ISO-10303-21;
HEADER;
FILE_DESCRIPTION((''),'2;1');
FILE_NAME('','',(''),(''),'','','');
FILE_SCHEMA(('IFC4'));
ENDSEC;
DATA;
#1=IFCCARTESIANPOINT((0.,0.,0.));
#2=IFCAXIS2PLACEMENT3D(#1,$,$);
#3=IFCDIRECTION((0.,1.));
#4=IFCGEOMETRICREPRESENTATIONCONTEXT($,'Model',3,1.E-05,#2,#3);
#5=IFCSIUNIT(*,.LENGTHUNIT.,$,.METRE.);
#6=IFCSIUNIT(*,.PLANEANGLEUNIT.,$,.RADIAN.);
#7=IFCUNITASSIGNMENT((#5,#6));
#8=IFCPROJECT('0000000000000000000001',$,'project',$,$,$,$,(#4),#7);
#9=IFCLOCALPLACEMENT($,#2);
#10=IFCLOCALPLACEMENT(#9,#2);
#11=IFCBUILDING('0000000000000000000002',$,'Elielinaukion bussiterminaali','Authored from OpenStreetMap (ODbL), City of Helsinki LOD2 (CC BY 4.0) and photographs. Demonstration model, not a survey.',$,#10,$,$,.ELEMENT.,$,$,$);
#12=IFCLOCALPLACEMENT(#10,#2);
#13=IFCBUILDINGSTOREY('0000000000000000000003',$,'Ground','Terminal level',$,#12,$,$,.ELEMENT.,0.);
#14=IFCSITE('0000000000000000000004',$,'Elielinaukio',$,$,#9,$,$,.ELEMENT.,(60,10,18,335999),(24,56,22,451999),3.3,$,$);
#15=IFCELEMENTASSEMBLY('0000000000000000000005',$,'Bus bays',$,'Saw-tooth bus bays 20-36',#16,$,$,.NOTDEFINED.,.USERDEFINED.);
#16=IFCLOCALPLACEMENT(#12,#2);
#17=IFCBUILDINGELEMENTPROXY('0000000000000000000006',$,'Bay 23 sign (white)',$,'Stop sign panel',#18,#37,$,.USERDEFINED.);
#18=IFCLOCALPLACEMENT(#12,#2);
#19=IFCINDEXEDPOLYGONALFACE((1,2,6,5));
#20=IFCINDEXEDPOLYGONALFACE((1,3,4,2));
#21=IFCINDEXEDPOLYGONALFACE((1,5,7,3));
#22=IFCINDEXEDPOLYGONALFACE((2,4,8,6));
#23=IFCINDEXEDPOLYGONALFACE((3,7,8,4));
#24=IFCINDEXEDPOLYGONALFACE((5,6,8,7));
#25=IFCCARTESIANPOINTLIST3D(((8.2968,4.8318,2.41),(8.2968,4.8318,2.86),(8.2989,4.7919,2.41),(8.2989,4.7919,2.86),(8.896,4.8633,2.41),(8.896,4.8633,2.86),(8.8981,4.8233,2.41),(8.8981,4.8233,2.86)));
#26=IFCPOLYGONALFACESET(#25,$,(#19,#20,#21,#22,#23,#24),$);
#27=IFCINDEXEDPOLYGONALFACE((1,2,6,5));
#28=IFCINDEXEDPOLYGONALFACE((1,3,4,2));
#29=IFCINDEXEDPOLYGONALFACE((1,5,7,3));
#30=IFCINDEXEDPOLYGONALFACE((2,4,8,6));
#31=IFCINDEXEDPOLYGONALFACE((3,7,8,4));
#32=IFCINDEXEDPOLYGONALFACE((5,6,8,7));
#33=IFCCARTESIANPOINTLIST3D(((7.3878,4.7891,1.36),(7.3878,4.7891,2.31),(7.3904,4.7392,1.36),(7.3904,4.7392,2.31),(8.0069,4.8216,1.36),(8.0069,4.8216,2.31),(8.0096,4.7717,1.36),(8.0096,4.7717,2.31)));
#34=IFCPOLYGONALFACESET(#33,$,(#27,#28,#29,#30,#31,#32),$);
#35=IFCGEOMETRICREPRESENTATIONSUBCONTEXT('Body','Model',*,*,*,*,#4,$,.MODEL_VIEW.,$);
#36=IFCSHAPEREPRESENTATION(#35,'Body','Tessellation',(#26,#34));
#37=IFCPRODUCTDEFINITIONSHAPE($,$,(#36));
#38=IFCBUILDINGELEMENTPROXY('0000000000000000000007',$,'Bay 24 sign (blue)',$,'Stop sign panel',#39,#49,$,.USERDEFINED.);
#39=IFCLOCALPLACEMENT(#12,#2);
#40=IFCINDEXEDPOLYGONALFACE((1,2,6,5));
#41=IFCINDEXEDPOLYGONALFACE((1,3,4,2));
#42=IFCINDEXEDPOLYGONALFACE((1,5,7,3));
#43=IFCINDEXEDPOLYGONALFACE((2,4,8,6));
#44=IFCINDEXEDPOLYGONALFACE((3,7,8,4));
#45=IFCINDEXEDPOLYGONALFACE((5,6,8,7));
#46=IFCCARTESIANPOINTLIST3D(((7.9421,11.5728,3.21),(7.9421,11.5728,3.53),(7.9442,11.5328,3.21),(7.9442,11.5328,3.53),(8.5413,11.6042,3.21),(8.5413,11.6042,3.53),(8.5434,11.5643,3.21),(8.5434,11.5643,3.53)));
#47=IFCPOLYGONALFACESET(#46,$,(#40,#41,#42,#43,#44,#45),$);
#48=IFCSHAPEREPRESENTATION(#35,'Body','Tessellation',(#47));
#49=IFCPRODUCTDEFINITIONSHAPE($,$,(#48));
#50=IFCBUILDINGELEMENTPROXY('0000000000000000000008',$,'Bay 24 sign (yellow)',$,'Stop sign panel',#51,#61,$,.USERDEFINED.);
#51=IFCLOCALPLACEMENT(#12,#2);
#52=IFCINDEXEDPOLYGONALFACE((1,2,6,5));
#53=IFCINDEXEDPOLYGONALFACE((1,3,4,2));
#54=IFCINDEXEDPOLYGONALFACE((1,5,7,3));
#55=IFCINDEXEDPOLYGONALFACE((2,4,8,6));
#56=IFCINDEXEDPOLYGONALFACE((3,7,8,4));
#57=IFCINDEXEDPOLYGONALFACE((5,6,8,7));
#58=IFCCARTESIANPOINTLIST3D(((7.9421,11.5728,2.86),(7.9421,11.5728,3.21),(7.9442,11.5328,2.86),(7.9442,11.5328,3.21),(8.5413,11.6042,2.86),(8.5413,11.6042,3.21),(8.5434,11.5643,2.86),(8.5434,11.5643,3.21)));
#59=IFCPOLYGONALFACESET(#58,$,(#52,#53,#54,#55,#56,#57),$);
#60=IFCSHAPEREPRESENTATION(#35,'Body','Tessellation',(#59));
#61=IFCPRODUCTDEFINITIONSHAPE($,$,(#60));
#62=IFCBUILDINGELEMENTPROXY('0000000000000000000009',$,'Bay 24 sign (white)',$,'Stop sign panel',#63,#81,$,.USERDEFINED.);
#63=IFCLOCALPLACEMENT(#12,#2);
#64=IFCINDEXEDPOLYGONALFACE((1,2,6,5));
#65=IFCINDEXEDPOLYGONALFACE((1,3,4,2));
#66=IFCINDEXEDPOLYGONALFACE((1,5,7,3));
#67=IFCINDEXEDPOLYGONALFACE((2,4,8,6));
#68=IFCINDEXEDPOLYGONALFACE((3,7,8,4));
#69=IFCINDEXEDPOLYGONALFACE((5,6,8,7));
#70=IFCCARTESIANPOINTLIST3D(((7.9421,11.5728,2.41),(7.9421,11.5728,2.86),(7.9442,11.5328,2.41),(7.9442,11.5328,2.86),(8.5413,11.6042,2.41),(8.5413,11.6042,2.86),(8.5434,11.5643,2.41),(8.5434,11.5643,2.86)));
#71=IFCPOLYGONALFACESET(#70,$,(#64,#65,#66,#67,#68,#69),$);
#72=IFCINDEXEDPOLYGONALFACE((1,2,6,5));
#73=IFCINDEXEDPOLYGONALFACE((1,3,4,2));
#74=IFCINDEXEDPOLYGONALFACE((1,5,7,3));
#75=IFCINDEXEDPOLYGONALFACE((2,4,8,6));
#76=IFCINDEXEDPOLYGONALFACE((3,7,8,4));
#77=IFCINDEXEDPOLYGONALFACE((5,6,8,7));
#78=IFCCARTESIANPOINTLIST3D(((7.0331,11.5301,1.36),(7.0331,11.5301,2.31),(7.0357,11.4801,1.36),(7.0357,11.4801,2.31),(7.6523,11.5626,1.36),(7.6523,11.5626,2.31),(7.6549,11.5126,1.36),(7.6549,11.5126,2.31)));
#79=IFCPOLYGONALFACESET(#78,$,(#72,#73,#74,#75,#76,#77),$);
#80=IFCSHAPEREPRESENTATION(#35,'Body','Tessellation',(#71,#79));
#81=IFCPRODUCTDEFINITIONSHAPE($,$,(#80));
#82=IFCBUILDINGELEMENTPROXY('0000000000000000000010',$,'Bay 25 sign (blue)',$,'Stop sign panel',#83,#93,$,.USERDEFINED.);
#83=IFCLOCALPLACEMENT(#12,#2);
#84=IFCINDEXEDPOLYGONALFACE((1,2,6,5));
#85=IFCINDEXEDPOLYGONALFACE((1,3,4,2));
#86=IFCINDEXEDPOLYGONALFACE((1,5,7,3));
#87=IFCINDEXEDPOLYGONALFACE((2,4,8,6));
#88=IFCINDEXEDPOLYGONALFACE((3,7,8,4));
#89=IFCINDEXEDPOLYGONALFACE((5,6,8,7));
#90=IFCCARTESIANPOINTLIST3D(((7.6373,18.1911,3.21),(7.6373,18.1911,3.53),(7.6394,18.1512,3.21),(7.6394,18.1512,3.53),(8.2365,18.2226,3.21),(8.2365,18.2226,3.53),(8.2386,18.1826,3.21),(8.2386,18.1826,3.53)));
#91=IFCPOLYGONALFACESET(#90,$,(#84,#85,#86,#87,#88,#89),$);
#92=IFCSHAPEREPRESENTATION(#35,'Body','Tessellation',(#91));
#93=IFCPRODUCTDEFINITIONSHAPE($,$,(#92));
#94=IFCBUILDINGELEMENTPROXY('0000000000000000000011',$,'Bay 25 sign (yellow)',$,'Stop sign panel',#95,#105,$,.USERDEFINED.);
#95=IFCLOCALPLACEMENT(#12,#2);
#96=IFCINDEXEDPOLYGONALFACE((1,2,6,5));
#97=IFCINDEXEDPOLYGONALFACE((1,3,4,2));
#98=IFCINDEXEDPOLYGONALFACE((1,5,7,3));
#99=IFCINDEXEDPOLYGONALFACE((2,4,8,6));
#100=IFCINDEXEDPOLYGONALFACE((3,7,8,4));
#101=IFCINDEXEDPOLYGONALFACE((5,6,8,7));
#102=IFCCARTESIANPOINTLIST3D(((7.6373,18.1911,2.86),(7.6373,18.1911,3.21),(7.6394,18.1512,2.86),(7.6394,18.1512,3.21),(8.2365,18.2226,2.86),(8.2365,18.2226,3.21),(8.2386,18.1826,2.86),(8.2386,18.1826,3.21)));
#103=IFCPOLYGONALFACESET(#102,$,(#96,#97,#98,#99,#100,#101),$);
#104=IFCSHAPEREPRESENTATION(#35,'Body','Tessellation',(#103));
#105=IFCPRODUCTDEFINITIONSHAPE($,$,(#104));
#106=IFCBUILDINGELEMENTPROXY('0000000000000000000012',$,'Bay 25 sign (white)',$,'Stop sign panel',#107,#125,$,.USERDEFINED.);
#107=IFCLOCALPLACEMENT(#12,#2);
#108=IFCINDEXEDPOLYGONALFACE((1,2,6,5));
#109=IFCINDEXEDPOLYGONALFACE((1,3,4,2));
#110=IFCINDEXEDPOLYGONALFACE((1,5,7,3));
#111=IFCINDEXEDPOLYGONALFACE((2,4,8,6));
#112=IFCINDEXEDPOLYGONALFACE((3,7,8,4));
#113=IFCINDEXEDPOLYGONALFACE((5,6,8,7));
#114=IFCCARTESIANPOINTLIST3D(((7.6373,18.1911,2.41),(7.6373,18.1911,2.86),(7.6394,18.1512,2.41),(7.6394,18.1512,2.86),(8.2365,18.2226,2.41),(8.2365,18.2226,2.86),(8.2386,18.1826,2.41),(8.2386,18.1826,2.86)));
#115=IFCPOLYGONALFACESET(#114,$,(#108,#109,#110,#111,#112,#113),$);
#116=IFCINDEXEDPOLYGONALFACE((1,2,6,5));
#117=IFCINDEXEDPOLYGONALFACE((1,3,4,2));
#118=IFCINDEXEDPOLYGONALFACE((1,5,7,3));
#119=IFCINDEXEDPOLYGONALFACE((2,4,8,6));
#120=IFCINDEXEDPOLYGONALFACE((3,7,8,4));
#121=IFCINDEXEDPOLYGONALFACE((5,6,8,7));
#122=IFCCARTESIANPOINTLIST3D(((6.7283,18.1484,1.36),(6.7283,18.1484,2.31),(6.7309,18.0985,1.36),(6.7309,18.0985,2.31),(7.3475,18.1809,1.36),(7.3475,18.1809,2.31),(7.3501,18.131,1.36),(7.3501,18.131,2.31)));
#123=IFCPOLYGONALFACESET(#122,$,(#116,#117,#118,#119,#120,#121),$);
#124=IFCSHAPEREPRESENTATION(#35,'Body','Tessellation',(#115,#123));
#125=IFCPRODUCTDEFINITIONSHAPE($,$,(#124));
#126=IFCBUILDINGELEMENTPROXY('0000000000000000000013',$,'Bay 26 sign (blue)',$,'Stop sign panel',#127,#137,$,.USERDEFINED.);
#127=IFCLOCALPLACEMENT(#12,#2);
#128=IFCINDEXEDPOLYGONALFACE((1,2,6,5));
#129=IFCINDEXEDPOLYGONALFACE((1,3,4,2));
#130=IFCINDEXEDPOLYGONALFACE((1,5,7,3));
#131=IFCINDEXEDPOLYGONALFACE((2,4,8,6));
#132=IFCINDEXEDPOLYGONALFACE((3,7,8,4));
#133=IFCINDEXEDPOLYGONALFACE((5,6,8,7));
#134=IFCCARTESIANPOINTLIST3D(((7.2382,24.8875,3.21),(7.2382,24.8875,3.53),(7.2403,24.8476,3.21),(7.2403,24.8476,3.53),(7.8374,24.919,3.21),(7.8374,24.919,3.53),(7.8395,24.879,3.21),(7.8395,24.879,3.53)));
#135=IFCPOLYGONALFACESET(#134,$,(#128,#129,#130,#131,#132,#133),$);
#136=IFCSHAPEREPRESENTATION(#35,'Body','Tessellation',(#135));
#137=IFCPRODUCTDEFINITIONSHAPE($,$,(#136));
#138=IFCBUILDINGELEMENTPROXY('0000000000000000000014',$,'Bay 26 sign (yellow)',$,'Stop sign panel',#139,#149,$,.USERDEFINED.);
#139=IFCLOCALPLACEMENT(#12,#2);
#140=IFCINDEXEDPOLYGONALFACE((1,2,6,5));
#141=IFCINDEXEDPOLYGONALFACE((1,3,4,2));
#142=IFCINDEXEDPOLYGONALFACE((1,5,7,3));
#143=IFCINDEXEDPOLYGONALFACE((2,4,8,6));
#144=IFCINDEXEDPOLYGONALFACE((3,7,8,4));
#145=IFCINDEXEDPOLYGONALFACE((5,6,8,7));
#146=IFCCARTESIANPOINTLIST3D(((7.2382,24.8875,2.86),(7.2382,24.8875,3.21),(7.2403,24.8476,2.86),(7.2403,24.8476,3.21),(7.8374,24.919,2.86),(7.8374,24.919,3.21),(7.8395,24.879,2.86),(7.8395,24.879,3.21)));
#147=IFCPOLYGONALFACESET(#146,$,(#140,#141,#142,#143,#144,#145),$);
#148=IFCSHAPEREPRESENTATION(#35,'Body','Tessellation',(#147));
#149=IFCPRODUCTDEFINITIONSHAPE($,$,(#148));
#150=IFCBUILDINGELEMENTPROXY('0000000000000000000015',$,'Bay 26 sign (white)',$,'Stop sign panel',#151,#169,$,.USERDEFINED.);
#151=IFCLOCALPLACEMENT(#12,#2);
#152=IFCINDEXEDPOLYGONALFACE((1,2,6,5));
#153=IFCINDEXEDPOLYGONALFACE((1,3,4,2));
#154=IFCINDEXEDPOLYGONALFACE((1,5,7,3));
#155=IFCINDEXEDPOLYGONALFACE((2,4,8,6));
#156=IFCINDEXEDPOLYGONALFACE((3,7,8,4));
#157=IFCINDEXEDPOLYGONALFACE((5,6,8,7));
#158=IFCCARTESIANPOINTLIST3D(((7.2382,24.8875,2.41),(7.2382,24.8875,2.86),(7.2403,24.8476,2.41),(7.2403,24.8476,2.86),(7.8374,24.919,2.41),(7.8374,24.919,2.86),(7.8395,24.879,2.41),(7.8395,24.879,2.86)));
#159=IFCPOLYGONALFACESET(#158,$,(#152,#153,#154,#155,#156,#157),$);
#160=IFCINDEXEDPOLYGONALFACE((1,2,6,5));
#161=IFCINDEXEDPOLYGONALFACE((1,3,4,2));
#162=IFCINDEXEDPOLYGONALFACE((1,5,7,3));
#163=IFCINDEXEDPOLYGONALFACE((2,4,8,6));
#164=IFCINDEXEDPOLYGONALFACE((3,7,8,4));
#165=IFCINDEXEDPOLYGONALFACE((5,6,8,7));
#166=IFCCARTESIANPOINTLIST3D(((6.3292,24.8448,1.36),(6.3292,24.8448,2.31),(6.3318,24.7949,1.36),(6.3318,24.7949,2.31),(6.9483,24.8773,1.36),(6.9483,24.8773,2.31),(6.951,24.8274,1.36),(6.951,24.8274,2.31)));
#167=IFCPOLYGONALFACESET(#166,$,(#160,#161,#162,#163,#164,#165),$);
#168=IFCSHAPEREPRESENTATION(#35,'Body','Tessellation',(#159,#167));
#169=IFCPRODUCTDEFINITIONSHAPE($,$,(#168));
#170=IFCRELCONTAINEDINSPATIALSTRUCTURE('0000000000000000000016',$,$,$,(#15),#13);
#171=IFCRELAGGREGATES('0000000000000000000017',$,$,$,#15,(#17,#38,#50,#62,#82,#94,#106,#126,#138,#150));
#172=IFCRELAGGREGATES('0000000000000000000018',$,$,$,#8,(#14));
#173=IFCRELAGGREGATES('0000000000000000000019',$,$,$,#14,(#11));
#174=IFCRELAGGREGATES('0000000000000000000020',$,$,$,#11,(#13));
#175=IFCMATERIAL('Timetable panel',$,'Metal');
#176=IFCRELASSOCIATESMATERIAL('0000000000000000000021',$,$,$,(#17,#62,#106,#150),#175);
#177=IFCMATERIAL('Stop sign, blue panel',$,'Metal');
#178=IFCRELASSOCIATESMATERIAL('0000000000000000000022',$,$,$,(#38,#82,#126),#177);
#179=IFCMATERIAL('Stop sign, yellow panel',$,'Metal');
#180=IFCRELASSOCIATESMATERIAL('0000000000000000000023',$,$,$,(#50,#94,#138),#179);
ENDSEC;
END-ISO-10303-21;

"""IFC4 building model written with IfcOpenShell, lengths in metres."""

from ifc_helpers import new_model, si_unit, direction, frame, frame_2d, origin, place, context, subcontext, project, spatial, rectangle, extrude, material, element, aggregate, save


model = new_model("IFC4")

# Units and contexts
model_context = context("Model", 3, precision=1e-05, world=origin(), true_north=direction((0.0, 1.0)))
body_context = subcontext(model_context, "Body", "Model", "MODEL_VIEW")
ifc_project = project(units=[si_unit("LENGTHUNIT", "METRE"), si_unit("PLANEANGLEUNIT", "RADIAN")], contexts=[model_context])

# Site, building, storey
site_placement = place(None, origin())
site = spatial("IfcSite", under=ifc_project, at=site_placement, Name="Elielinaukio", CompositionType="ELEMENT", RefLatitude=(60, 10, 18, 335999), RefLongitude=(24, 56, 22, 451999), RefElevation=3.3)
building_placement = place(site_placement, origin())
building = spatial("IfcBuilding", under=site, at=building_placement, Name="Elielinaukion bussiterminaali", Description="Authored from OpenStreetMap (ODbL), City of Helsinki LOD2 (CC BY 4.0) and photographs. Demonstration model, not a survey.", CompositionType="ELEMENT")
storey_placement = place(building_placement, origin())
storey = spatial("IfcBuildingStorey", under=building, at=storey_placement, Name="Ground", Description="Terminal level", CompositionType="ELEMENT", Elevation=0.0)

# Element assembly, building element proxies
assembly_placement = place(building_placement, origin())
assembly = element("IfcElementAssembly", 1, at=assembly_placement, inside=storey, Name="Bus bays", ObjectType="Saw-tooth bus bays 20-36", AssemblyPlace="NOTDEFINED", PredefinedType="USERDEFINED")
ifc_material_1 = material(Name="Stop sign, blue panel", Category="Metal")
ifc_material_2 = material(Name="Stop sign, yellow panel", Category="Metal")
ifc_material_3 = material(Name="Timetable panel", Category="Metal")
proxy_1_placement = place(building_placement, origin())
proxy_1 = element("IfcBuildingElementProxy", 2, at=proxy_1_placement, material=ifc_material_3, Name="Bay 23 sign (white)", ObjectType="Stop sign panel", PredefinedType="USERDEFINED", context=body_context, shape_type="SweptSolid", body=[
    extrude(rectangle(XDim=0.04, YDim=0.6, at=frame_2d((0.0, 0.0), x_axis=(-0.052408, 0.998626))), frame((8.5974, 4.8276, 2.41)), (0.0, 0.0, 1.0), 0.45),
    extrude(rectangle(XDim=0.05, YDim=0.62, at=frame_2d((0.0, 0.0), x_axis=(-0.052408, 0.998626))), frame((7.6987, 4.7804, 1.36)), (0.0, 0.0, 1.0), 0.95),
])
proxy_2_placement = place(building_placement, origin())
proxy_2 = element("IfcBuildingElementProxy", 3, at=proxy_2_placement, material=ifc_material_1, Name="Bay 24 sign (blue)", ObjectType="Stop sign panel", PredefinedType="USERDEFINED", context=body_context, shape_type="SweptSolid", body=[
    extrude(rectangle(XDim=0.04, YDim=0.6, at=frame_2d((0.0, 0.0), x_axis=(-0.052408, 0.998626))), frame((8.2428, 11.5685, 3.21)), (0.0, 0.0, 1.0), 0.32),
])
proxy_3_placement = place(building_placement, origin())
proxy_3 = element("IfcBuildingElementProxy", 4, at=proxy_3_placement, material=ifc_material_2, Name="Bay 24 sign (yellow)", ObjectType="Stop sign panel", PredefinedType="USERDEFINED", context=body_context, shape_type="SweptSolid", body=[
    extrude(rectangle(XDim=0.04, YDim=0.6, at=frame_2d((0.0, 0.0), x_axis=(-0.052408, 0.998626))), frame((8.2428, 11.5685, 2.86)), (0.0, 0.0, 1.0), 0.35),
])
proxy_4_placement = place(building_placement, origin())
proxy_4 = element("IfcBuildingElementProxy", 5, at=proxy_4_placement, material=ifc_material_3, Name="Bay 24 sign (white)", ObjectType="Stop sign panel", PredefinedType="USERDEFINED", context=body_context, shape_type="SweptSolid", body=[
    extrude(rectangle(XDim=0.04, YDim=0.6, at=frame_2d((0.0, 0.0), x_axis=(-0.052408, 0.998626))), frame((8.2428, 11.5685, 2.41)), (0.0, 0.0, 1.0), 0.45),
    extrude(rectangle(XDim=0.05, YDim=0.62, at=frame_2d((0.0, 0.0), x_axis=(-0.052408, 0.998626))), frame((7.344, 11.5213, 1.36)), (0.0, 0.0, 1.0), 0.95),
])
proxy_5_placement = place(building_placement, origin())
proxy_5 = element("IfcBuildingElementProxy", 6, at=proxy_5_placement, material=ifc_material_1, Name="Bay 25 sign (blue)", ObjectType="Stop sign panel", PredefinedType="USERDEFINED", context=body_context, shape_type="SweptSolid", body=[
    extrude(rectangle(XDim=0.04, YDim=0.6, at=frame_2d((0.0, 0.0), x_axis=(-0.052408, 0.998626))), frame((7.938, 18.1869, 3.21)), (0.0, 0.0, 1.0), 0.32),
])
proxy_6_placement = place(building_placement, origin())
proxy_6 = element("IfcBuildingElementProxy", 7, at=proxy_6_placement, material=ifc_material_2, Name="Bay 25 sign (yellow)", ObjectType="Stop sign panel", PredefinedType="USERDEFINED", context=body_context, shape_type="SweptSolid", body=[
    extrude(rectangle(XDim=0.04, YDim=0.6, at=frame_2d((0.0, 0.0), x_axis=(-0.052408, 0.998626))), frame((7.938, 18.1869, 2.86)), (0.0, 0.0, 1.0), 0.35),
])
proxy_7_placement = place(building_placement, origin())
proxy_7 = element("IfcBuildingElementProxy", 8, at=proxy_7_placement, material=ifc_material_3, Name="Bay 25 sign (white)", ObjectType="Stop sign panel", PredefinedType="USERDEFINED", context=body_context, shape_type="SweptSolid", body=[
    extrude(rectangle(XDim=0.04, YDim=0.6, at=frame_2d((0.0, 0.0), x_axis=(-0.052408, 0.998626))), frame((7.938, 18.1869, 2.41)), (0.0, 0.0, 1.0), 0.45),
    extrude(rectangle(XDim=0.05, YDim=0.62, at=frame_2d((0.0, 0.0), x_axis=(-0.052408, 0.998626))), frame((7.0392, 18.1397, 1.36)), (0.0, 0.0, 1.0), 0.95),
])
proxy_8_placement = place(building_placement, origin())
proxy_8 = element("IfcBuildingElementProxy", 9, at=proxy_8_placement, material=ifc_material_1, Name="Bay 26 sign (blue)", ObjectType="Stop sign panel", PredefinedType="USERDEFINED", context=body_context, shape_type="SweptSolid", body=[
    extrude(rectangle(XDim=0.04, YDim=0.6, at=frame_2d((0.0, 0.0), x_axis=(-0.052408, 0.998626))), frame((7.5388, 24.8833, 3.21)), (0.0, 0.0, 1.0), 0.32),
])
proxy_9_placement = place(building_placement, origin())
proxy_9 = element("IfcBuildingElementProxy", 10, at=proxy_9_placement, material=ifc_material_2, Name="Bay 26 sign (yellow)", ObjectType="Stop sign panel", PredefinedType="USERDEFINED", context=body_context, shape_type="SweptSolid", body=[
    extrude(rectangle(XDim=0.04, YDim=0.6, at=frame_2d((0.0, 0.0), x_axis=(-0.052408, 0.998626))), frame((7.5388, 24.8833, 2.86)), (0.0, 0.0, 1.0), 0.35),
])
proxy_10_placement = place(building_placement, origin())
proxy_10 = element("IfcBuildingElementProxy", 11, at=proxy_10_placement, material=ifc_material_3, Name="Bay 26 sign (white)", ObjectType="Stop sign panel", PredefinedType="USERDEFINED", context=body_context, shape_type="SweptSolid", body=[
    extrude(rectangle(XDim=0.04, YDim=0.6, at=frame_2d((0.0, 0.0), x_axis=(-0.052408, 0.998626))), frame((7.5388, 24.8833, 2.41)), (0.0, 0.0, 1.0), 0.45),
    extrude(rectangle(XDim=0.05, YDim=0.62, at=frame_2d((0.0, 0.0), x_axis=(-0.052408, 0.998626))), frame((6.6401, 24.8361, 1.36)), (0.0, 0.0, 1.0), 0.95),
])
aggregate(assembly, [proxy_1, proxy_2, proxy_3, proxy_4, proxy_5, proxy_6, proxy_7, proxy_8, proxy_9, proxy_10])

save(model, "model.ifc")
